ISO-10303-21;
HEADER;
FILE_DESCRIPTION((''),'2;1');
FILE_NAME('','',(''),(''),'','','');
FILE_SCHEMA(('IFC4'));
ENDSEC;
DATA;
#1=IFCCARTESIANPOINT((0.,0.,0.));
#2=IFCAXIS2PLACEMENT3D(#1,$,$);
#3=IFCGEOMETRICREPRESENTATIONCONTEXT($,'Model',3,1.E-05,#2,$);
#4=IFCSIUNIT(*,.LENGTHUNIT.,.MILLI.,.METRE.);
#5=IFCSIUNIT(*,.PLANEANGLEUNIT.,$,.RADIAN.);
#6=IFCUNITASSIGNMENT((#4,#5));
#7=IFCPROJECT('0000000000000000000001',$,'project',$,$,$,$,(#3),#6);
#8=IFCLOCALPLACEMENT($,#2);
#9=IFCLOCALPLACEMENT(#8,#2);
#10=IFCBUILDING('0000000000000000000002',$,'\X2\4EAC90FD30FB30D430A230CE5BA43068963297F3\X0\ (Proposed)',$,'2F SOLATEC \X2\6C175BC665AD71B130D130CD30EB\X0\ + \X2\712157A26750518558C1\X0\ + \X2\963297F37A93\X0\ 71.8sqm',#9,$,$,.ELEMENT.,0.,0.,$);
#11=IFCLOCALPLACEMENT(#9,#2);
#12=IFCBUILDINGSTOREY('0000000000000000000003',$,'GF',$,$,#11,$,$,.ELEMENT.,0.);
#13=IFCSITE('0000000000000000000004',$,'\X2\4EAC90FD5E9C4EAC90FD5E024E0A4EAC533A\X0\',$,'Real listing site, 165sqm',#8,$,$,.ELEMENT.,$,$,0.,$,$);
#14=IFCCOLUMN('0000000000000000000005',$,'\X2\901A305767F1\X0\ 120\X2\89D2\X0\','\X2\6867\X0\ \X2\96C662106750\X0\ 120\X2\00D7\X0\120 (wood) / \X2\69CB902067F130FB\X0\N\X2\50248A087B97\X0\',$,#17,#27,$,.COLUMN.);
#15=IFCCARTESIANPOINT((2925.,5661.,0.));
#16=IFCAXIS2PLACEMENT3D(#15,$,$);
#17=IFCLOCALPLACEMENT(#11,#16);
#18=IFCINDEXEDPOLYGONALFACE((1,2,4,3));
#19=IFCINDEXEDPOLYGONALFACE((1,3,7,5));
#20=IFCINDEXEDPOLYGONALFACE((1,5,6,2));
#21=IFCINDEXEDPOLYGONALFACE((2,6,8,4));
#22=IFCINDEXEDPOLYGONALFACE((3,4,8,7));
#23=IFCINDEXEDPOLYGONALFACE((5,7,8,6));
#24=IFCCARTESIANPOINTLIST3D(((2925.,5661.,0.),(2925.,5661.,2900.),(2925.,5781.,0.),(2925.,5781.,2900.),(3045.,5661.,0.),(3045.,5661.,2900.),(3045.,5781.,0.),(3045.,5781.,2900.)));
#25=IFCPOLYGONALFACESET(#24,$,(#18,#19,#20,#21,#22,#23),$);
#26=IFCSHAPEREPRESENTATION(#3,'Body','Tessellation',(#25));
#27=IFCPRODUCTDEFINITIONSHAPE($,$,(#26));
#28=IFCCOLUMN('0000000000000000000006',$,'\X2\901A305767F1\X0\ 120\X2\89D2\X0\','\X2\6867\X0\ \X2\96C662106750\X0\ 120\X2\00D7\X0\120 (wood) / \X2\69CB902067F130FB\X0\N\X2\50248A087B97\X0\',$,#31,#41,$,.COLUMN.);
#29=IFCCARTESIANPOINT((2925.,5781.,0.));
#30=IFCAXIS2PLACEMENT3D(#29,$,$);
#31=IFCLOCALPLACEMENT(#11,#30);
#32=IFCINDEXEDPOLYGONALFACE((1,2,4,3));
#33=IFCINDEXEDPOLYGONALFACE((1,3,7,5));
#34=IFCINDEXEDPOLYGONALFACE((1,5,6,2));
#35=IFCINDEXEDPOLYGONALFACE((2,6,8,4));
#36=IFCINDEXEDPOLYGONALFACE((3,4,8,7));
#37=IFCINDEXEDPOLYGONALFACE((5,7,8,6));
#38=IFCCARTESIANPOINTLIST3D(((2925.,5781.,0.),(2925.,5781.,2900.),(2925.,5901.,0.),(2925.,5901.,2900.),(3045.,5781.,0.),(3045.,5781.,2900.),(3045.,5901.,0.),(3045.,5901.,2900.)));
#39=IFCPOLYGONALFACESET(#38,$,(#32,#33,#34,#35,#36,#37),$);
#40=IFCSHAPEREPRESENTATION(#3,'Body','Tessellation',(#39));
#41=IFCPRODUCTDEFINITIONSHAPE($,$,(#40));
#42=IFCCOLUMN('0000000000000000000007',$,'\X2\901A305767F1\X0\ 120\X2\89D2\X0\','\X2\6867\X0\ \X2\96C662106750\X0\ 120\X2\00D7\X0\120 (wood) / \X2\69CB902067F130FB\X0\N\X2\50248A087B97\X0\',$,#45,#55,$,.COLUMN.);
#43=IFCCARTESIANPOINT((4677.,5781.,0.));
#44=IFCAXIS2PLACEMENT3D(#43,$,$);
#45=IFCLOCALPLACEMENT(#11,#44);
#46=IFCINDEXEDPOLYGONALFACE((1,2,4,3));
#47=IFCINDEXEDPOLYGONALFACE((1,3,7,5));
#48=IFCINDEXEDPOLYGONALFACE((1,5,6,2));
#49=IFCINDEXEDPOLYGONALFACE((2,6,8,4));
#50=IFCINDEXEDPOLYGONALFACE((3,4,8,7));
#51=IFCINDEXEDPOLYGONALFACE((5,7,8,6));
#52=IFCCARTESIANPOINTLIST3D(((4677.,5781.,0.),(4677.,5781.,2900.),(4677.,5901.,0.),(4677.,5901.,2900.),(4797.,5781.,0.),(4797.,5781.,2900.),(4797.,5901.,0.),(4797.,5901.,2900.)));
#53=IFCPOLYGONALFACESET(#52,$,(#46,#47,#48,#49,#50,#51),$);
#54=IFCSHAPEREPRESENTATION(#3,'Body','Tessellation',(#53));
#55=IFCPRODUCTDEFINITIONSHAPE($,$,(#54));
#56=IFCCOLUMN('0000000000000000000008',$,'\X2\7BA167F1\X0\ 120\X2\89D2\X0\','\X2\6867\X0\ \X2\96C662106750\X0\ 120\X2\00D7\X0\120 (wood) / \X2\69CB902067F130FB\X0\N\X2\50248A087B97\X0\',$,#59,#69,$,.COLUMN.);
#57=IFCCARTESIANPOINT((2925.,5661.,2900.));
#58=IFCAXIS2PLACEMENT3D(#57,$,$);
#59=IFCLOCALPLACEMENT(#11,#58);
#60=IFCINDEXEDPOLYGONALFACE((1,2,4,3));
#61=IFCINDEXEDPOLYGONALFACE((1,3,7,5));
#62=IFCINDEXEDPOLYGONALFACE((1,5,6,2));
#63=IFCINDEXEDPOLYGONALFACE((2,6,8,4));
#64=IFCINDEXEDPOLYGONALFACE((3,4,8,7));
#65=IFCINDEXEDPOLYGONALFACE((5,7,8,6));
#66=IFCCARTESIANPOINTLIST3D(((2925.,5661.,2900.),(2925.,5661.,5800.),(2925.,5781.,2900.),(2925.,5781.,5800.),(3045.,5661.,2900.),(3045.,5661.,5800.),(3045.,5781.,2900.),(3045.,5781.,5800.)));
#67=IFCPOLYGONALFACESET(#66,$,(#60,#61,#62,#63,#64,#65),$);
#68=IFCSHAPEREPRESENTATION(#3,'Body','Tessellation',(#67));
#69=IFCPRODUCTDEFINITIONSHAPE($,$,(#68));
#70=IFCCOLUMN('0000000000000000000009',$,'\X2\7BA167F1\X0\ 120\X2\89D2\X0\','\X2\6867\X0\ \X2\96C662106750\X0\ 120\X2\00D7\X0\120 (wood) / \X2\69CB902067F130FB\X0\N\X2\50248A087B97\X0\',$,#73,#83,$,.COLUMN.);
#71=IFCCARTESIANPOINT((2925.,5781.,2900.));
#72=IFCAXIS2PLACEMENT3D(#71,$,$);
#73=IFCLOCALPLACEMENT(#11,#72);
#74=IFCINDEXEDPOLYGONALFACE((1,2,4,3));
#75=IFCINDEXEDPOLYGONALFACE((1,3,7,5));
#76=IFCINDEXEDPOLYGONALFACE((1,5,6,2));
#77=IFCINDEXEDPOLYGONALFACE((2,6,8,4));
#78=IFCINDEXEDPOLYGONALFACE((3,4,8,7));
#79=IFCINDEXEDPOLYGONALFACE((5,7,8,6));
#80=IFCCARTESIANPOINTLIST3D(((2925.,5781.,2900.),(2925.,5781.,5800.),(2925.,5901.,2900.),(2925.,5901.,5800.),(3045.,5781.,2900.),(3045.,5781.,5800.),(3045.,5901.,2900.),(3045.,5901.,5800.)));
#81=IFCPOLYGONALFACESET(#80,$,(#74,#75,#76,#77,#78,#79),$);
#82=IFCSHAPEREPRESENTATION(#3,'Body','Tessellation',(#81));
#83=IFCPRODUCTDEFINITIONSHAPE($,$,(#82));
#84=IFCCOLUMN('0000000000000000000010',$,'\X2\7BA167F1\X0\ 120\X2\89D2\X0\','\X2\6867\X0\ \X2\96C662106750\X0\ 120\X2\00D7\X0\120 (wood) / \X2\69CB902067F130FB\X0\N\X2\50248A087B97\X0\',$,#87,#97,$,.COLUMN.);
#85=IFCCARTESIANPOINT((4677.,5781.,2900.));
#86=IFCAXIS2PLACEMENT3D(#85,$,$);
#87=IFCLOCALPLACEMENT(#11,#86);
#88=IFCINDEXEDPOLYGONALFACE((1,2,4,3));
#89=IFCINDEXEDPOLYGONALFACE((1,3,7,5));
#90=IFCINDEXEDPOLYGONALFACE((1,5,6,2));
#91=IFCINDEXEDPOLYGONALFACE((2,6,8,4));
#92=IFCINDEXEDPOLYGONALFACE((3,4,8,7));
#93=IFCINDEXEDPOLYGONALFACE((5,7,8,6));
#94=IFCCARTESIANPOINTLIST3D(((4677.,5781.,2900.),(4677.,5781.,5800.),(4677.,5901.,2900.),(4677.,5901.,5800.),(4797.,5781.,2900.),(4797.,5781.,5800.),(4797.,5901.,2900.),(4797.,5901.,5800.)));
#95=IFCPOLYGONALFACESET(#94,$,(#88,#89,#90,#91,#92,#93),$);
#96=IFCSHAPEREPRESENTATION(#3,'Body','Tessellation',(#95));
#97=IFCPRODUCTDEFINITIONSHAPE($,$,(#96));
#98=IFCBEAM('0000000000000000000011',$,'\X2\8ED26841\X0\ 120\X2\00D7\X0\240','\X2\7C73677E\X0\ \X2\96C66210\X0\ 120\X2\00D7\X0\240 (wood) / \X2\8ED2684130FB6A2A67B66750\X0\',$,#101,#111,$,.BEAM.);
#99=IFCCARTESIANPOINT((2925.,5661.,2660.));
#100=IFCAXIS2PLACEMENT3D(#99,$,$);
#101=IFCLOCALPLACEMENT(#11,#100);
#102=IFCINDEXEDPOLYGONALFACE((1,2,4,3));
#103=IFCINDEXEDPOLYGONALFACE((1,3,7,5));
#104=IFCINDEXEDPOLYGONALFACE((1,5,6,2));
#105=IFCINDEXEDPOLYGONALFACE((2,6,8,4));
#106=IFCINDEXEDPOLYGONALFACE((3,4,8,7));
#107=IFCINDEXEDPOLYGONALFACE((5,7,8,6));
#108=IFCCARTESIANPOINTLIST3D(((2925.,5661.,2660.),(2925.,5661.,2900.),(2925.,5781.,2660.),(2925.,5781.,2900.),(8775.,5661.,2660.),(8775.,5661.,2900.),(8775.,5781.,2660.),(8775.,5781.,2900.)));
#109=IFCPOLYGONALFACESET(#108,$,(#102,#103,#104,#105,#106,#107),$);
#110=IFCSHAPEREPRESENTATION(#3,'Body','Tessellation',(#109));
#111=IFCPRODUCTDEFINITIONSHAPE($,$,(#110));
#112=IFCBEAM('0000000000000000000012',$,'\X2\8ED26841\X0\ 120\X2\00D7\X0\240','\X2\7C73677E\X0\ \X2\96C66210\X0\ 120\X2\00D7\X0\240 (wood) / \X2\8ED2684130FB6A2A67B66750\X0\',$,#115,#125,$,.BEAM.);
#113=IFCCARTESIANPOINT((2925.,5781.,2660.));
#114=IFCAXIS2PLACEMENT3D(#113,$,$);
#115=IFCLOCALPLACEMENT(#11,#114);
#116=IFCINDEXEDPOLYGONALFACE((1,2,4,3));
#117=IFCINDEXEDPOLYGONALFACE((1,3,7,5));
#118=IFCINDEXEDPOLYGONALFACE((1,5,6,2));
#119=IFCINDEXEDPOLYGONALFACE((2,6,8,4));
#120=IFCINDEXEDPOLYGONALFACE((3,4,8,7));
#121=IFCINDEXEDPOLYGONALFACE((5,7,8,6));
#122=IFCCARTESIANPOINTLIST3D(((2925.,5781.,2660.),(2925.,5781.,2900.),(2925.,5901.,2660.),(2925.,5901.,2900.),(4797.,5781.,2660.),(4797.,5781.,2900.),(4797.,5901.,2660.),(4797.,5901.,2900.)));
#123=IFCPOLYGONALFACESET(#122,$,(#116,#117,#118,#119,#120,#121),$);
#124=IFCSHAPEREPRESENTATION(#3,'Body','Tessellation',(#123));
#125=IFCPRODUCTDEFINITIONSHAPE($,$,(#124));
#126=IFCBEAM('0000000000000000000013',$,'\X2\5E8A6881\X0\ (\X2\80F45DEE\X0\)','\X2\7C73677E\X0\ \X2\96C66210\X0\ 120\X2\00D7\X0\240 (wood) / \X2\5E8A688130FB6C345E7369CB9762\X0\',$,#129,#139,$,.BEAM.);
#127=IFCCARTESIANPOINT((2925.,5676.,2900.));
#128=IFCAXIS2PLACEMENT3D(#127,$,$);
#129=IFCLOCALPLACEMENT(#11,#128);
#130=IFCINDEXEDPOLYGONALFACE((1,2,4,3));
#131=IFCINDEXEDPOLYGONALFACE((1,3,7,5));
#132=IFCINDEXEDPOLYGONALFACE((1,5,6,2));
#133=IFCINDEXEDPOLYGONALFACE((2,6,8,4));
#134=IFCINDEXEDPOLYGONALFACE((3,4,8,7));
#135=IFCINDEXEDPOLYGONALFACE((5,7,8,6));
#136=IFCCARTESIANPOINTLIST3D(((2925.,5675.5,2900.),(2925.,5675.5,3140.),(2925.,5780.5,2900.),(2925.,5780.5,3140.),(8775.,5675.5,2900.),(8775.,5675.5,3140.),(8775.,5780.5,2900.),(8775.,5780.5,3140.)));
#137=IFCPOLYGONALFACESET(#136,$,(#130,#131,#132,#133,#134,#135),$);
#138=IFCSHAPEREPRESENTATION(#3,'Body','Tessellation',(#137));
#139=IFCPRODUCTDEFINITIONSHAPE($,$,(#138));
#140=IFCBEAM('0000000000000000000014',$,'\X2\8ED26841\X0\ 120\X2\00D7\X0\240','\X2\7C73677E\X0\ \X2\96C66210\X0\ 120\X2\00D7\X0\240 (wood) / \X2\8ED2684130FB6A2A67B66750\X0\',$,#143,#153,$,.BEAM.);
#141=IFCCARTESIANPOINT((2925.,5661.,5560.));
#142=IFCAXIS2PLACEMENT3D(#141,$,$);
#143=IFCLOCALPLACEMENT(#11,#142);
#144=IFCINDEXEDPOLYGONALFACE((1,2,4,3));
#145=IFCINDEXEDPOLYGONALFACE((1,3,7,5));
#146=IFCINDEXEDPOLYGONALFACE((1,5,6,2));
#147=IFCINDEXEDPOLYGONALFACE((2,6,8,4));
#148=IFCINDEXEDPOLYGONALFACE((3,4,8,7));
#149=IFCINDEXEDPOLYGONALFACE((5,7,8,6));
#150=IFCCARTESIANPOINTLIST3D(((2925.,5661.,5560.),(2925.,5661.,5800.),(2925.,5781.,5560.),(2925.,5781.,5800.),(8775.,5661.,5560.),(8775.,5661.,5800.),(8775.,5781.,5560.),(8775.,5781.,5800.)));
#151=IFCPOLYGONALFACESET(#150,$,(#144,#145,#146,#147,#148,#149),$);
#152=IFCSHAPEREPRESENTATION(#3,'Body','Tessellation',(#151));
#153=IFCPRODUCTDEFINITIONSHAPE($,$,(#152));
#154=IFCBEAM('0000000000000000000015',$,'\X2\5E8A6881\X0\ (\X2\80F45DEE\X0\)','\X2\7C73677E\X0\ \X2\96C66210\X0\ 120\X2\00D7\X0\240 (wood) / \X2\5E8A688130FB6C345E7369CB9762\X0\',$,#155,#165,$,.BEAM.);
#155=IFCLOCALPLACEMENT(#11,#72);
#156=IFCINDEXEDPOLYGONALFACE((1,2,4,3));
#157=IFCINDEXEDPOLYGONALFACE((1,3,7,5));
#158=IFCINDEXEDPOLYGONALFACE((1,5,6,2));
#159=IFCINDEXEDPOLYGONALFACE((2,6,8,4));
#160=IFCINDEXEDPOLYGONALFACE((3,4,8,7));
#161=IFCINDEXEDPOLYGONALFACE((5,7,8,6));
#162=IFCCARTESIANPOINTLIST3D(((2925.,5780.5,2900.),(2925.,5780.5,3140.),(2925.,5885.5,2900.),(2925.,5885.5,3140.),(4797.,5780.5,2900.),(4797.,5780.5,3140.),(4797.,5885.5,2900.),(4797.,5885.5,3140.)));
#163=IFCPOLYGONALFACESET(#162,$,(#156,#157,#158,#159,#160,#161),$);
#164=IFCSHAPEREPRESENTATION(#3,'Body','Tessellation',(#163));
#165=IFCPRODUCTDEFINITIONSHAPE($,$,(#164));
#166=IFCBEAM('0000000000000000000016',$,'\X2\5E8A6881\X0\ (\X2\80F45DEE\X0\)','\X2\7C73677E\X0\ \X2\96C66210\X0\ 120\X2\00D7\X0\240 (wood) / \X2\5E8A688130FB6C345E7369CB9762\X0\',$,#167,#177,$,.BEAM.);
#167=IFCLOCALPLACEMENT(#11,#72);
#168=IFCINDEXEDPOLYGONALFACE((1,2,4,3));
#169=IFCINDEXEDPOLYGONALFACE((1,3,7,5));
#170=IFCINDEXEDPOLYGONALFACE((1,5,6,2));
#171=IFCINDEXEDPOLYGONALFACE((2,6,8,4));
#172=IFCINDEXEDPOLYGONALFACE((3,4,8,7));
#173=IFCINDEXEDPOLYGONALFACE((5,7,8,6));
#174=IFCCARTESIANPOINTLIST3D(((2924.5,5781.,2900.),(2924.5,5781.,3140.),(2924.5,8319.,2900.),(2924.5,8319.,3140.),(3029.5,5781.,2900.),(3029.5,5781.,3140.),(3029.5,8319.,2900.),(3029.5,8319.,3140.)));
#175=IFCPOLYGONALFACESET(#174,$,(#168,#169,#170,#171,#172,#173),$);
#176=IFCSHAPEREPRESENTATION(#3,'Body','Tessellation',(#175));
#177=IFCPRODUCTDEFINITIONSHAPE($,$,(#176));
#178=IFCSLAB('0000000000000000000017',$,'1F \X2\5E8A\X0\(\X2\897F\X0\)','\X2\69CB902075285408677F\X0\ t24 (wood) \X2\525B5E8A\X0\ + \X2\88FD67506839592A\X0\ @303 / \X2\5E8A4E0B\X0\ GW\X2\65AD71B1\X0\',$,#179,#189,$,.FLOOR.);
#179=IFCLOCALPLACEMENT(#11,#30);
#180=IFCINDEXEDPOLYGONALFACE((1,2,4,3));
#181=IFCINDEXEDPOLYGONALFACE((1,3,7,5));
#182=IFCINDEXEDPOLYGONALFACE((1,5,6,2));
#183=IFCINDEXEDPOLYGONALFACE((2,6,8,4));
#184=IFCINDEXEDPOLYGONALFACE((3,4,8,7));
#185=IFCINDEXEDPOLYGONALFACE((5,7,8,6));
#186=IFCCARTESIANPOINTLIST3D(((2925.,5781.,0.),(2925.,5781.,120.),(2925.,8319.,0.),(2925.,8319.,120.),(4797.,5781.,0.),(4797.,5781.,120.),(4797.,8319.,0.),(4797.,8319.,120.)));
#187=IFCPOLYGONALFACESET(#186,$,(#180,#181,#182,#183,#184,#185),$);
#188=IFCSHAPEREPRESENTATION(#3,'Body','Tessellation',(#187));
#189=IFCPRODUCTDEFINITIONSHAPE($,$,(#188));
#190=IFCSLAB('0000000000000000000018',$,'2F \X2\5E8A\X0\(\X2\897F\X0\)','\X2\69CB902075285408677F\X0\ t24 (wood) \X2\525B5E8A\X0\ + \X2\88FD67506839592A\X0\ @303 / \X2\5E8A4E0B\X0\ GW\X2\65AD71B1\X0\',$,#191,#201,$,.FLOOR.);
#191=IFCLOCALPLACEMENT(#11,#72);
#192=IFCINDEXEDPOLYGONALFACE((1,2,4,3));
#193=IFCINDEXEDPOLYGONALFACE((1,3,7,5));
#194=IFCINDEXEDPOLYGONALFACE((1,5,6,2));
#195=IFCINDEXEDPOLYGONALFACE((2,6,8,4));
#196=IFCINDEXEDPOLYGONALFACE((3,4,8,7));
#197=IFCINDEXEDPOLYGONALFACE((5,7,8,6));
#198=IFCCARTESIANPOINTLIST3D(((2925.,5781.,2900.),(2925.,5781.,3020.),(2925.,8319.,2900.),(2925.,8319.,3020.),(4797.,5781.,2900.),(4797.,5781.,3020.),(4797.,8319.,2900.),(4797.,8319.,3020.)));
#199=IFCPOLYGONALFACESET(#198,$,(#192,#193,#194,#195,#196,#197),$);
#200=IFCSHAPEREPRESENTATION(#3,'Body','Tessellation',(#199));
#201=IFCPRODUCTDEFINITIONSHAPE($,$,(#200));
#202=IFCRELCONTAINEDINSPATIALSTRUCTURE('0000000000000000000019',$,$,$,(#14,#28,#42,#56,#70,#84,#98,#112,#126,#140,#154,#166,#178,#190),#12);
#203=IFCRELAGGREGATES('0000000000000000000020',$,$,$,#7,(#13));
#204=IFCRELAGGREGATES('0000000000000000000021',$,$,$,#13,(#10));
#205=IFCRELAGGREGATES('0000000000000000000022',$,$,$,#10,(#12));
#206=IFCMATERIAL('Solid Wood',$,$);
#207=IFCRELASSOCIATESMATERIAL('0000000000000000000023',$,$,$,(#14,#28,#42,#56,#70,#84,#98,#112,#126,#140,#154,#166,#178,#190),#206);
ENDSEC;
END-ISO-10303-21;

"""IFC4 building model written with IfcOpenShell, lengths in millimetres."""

from ifc_helpers import new_model, si_unit, frame, frame_2d, origin, place, context, project, spatial, rectangle, extrude, material, element, save


model = new_model("IFC4")

# Units and contexts
model_context = context("Model", 3, precision=1e-05, world=origin())
ifc_project = project(units=[si_unit("LENGTHUNIT", "METRE", prefix="MILLI"), si_unit("PLANEANGLEUNIT", "RADIAN")], contexts=[model_context])

# Site, building, storey
site_placement = place(None, origin())
site = spatial("IfcSite", under=ifc_project, at=site_placement, Name="京都府京都市上京区", ObjectType="Real listing site, 165sqm", CompositionType="ELEMENT", RefElevation=0.0)
building_placement = place(site_placement, origin())
building = spatial("IfcBuilding", under=site, at=building_placement, Name="京都・ピアノ室と防音 (Proposed)", ObjectType="2F SOLATEC 気密断熱パネル + 無垢材内壁 + 防音窓 71.8sqm", CompositionType="ELEMENT", ElevationOfRefHeight=0.0, ElevationOfTerrain=0.0)
storey_placement = place(building_placement, origin())
storey = spatial("IfcBuildingStorey", under=building, at=storey_placement, Name="GF", CompositionType="ELEMENT", Elevation=0.0)

# Columns
ifc_material_1 = material(Name="Solid Wood")
column_1_placement = place(storey_placement, frame((2925.0, 5661.0, 0.0)))
element("IfcColumn", 1, at=column_1_placement, inside=storey, material=ifc_material_1, Name="通し柱 120角", Description="桧 集成材 120×120 (wood) / 構造柱・N値計算", PredefinedType="COLUMN", context=model_context, shape_type="SweptSolid", body=[
    extrude(rectangle(XDim=120.0, YDim=120.0, at=frame_2d((60.0, 60.0))), frame((2925.0, 5661.0, 0.0)), (0.0, 0.0, 1.0), 2900.0),
])
column_2_placement = place(storey_placement, frame((2925.0, 5781.0, 0.0)))
element("IfcColumn", 2, at=column_2_placement, inside=storey, material=ifc_material_1, Name="通し柱 120角", Description="桧 集成材 120×120 (wood) / 構造柱・N値計算", PredefinedType="COLUMN", context=model_context, shape_type="SweptSolid", body=[
    extrude(rectangle(XDim=120.0, YDim=120.0, at=frame_2d((60.0, 60.0))), frame((2925.0, 5781.0, 0.0)), (0.0, 0.0, 1.0), 2900.0),
])
column_3_placement = place(storey_placement, frame((4677.0, 5781.0, 0.0)))
element("IfcColumn", 3, at=column_3_placement, inside=storey, material=ifc_material_1, Name="通し柱 120角", Description="桧 集成材 120×120 (wood) / 構造柱・N値計算", PredefinedType="COLUMN", context=model_context, shape_type="SweptSolid", body=[
    extrude(rectangle(XDim=120.0, YDim=120.0, at=frame_2d((60.0, 60.0))), frame((4677.0, 5781.0, 0.0)), (0.0, 0.0, 1.0), 2900.0),
])
column_4_placement = place(storey_placement, frame((2925.0, 5661.0, 2900.0)))
element("IfcColumn", 4, at=column_4_placement, inside=storey, material=ifc_material_1, Name="管柱 120角", Description="桧 集成材 120×120 (wood) / 構造柱・N値計算", PredefinedType="COLUMN", context=model_context, shape_type="SweptSolid", body=[
    extrude(rectangle(XDim=120.0, YDim=120.0, at=frame_2d((60.0, 60.0))), frame((2925.0, 5661.0, 2900.0)), (0.0, 0.0, 1.0), 2900.0),
])
column_5_placement = place(storey_placement, frame((2925.0, 5781.0, 2900.0)))
element("IfcColumn", 5, at=column_5_placement, inside=storey, material=ifc_material_1, Name="管柱 120角", Description="桧 集成材 120×120 (wood) / 構造柱・N値計算", PredefinedType="COLUMN", context=model_context, shape_type="SweptSolid", body=[
    extrude(rectangle(XDim=120.0, YDim=120.0, at=frame_2d((60.0, 60.0))), frame((2925.0, 5781.0, 2900.0)), (0.0, 0.0, 1.0), 2900.0),
])
column_6_placement = place(storey_placement, frame((4677.0, 5781.0, 2900.0)))
element("IfcColumn", 6, at=column_6_placement, inside=storey, material=ifc_material_1, Name="管柱 120角", Description="桧 集成材 120×120 (wood) / 構造柱・N値計算", PredefinedType="COLUMN", context=model_context, shape_type="SweptSolid", body=[
    extrude(rectangle(XDim=120.0, YDim=120.0, at=frame_2d((60.0, 60.0))), frame((4677.0, 5781.0, 2900.0)), (0.0, 0.0, 1.0), 2900.0),
])

# Beams
beam_1_placement = place(storey_placement, frame((2925.0, 5661.0, 2660.0)))
element("IfcBeam", 7, at=beam_1_placement, inside=storey, material=ifc_material_1, Name="軒桁 120×240", Description="米松 集成 120×240 (wood) / 軒桁・横架材", PredefinedType="BEAM", context=model_context, shape_type="SweptSolid", body=[
    extrude(rectangle(XDim=5850.0, YDim=120.0, at=frame_2d((2925.0, 60.0))), frame((2925.0, 5661.0, 2660.0)), (0.0, 0.0, 1.0), 240.0),
])
beam_2_placement = place(storey_placement, frame((2925.0, 5781.0, 2660.0)))
element("IfcBeam", 8, at=beam_2_placement, inside=storey, material=ifc_material_1, Name="軒桁 120×240", Description="米松 集成 120×240 (wood) / 軒桁・横架材", PredefinedType="BEAM", context=model_context, shape_type="SweptSolid", body=[
    extrude(rectangle(XDim=1872.0, YDim=120.0, at=frame_2d((936.0, 60.0))), frame((2925.0, 5781.0, 2660.0)), (0.0, 0.0, 1.0), 240.0),
])
beam_3_placement = place(storey_placement, frame((2925.0, 5676.0, 2900.0)))
element("IfcBeam", 9, at=beam_3_placement, inside=storey, material=ifc_material_1, Name="床梁 (胴差)", Description="米松 集成 120×240 (wood) / 床梁・水平構面", PredefinedType="BEAM", context=model_context, shape_type="SweptSolid", body=[
    extrude(rectangle(XDim=5850.0, YDim=105.0, at=frame_2d((2925.0, 52.0))), frame((2925.0, 5676.0, 2900.0)), (0.0, 0.0, 1.0), 240.0),
])
beam_4_placement = place(storey_placement, frame((2925.0, 5661.0, 5560.0)))
element("IfcBeam", 10, at=beam_4_placement, inside=storey, material=ifc_material_1, Name="軒桁 120×240", Description="米松 集成 120×240 (wood) / 軒桁・横架材", PredefinedType="BEAM", context=model_context, shape_type="SweptSolid", body=[
    extrude(rectangle(XDim=5850.0, YDim=120.0, at=frame_2d((2925.0, 60.0))), frame((2925.0, 5661.0, 5560.0)), (0.0, 0.0, 1.0), 240.0),
])
beam_5_placement = place(storey_placement, frame((2925.0, 5781.0, 2900.0)))
element("IfcBeam", 11, at=beam_5_placement, inside=storey, material=ifc_material_1, Name="床梁 (胴差)", Description="米松 集成 120×240 (wood) / 床梁・水平構面", PredefinedType="BEAM", context=model_context, shape_type="SweptSolid", body=[
    extrude(rectangle(XDim=1872.0, YDim=105.0, at=frame_2d((936.0, 52.0))), frame((2925.0, 5781.0, 2900.0)), (0.0, 0.0, 1.0), 240.0),
])
beam_6_placement = place(storey_placement, frame((2925.0, 5781.0, 2900.0)))
element("IfcBeam", 12, at=beam_6_placement, inside=storey, material=ifc_material_1, Name="床梁 (胴差)", Description="米松 集成 120×240 (wood) / 床梁・水平構面", PredefinedType="BEAM", context=model_context, shape_type="SweptSolid", body=[
    extrude(rectangle(XDim=105.0, YDim=2538.0, at=frame_2d((52.0, 1269.0))), frame((2925.0, 5781.0, 2900.0)), (0.0, 0.0, 1.0), 240.0),
])

# Slabs
slab_1_placement = place(storey_placement, frame((2925.0, 5781.0, 0.0)))
element("IfcSlab", 13, at=slab_1_placement, inside=storey, material=ifc_material_1, Name="1F 床(西)", Description="構造用合板 t24 (wood) 剛床 + 製材根太 @303 / 床下 GW断熱", PredefinedType="FLOOR", context=model_context, shape_type="SweptSolid", body=[
    extrude(rectangle(XDim=1872.0, YDim=2538.0, at=frame_2d((936.0, 1269.0))), frame((2925.0, 5781.0, 0.0)), (0.0, 0.0, 1.0), 120.0),
])
slab_2_placement = place(storey_placement, frame((2925.0, 5781.0, 2900.0)))
element("IfcSlab", 14, at=slab_2_placement, inside=storey, material=ifc_material_1, Name="2F 床(西)", Description="構造用合板 t24 (wood) 剛床 + 製材根太 @303 / 床下 GW断熱", PredefinedType="FLOOR", context=model_context, shape_type="SweptSolid", body=[
    extrude(rectangle(XDim=1872.0, YDim=2538.0, at=frame_2d((936.0, 1269.0))), frame((2925.0, 5781.0, 2900.0)), (0.0, 0.0, 1.0), 120.0),
])

save(model, "model.ifc")
